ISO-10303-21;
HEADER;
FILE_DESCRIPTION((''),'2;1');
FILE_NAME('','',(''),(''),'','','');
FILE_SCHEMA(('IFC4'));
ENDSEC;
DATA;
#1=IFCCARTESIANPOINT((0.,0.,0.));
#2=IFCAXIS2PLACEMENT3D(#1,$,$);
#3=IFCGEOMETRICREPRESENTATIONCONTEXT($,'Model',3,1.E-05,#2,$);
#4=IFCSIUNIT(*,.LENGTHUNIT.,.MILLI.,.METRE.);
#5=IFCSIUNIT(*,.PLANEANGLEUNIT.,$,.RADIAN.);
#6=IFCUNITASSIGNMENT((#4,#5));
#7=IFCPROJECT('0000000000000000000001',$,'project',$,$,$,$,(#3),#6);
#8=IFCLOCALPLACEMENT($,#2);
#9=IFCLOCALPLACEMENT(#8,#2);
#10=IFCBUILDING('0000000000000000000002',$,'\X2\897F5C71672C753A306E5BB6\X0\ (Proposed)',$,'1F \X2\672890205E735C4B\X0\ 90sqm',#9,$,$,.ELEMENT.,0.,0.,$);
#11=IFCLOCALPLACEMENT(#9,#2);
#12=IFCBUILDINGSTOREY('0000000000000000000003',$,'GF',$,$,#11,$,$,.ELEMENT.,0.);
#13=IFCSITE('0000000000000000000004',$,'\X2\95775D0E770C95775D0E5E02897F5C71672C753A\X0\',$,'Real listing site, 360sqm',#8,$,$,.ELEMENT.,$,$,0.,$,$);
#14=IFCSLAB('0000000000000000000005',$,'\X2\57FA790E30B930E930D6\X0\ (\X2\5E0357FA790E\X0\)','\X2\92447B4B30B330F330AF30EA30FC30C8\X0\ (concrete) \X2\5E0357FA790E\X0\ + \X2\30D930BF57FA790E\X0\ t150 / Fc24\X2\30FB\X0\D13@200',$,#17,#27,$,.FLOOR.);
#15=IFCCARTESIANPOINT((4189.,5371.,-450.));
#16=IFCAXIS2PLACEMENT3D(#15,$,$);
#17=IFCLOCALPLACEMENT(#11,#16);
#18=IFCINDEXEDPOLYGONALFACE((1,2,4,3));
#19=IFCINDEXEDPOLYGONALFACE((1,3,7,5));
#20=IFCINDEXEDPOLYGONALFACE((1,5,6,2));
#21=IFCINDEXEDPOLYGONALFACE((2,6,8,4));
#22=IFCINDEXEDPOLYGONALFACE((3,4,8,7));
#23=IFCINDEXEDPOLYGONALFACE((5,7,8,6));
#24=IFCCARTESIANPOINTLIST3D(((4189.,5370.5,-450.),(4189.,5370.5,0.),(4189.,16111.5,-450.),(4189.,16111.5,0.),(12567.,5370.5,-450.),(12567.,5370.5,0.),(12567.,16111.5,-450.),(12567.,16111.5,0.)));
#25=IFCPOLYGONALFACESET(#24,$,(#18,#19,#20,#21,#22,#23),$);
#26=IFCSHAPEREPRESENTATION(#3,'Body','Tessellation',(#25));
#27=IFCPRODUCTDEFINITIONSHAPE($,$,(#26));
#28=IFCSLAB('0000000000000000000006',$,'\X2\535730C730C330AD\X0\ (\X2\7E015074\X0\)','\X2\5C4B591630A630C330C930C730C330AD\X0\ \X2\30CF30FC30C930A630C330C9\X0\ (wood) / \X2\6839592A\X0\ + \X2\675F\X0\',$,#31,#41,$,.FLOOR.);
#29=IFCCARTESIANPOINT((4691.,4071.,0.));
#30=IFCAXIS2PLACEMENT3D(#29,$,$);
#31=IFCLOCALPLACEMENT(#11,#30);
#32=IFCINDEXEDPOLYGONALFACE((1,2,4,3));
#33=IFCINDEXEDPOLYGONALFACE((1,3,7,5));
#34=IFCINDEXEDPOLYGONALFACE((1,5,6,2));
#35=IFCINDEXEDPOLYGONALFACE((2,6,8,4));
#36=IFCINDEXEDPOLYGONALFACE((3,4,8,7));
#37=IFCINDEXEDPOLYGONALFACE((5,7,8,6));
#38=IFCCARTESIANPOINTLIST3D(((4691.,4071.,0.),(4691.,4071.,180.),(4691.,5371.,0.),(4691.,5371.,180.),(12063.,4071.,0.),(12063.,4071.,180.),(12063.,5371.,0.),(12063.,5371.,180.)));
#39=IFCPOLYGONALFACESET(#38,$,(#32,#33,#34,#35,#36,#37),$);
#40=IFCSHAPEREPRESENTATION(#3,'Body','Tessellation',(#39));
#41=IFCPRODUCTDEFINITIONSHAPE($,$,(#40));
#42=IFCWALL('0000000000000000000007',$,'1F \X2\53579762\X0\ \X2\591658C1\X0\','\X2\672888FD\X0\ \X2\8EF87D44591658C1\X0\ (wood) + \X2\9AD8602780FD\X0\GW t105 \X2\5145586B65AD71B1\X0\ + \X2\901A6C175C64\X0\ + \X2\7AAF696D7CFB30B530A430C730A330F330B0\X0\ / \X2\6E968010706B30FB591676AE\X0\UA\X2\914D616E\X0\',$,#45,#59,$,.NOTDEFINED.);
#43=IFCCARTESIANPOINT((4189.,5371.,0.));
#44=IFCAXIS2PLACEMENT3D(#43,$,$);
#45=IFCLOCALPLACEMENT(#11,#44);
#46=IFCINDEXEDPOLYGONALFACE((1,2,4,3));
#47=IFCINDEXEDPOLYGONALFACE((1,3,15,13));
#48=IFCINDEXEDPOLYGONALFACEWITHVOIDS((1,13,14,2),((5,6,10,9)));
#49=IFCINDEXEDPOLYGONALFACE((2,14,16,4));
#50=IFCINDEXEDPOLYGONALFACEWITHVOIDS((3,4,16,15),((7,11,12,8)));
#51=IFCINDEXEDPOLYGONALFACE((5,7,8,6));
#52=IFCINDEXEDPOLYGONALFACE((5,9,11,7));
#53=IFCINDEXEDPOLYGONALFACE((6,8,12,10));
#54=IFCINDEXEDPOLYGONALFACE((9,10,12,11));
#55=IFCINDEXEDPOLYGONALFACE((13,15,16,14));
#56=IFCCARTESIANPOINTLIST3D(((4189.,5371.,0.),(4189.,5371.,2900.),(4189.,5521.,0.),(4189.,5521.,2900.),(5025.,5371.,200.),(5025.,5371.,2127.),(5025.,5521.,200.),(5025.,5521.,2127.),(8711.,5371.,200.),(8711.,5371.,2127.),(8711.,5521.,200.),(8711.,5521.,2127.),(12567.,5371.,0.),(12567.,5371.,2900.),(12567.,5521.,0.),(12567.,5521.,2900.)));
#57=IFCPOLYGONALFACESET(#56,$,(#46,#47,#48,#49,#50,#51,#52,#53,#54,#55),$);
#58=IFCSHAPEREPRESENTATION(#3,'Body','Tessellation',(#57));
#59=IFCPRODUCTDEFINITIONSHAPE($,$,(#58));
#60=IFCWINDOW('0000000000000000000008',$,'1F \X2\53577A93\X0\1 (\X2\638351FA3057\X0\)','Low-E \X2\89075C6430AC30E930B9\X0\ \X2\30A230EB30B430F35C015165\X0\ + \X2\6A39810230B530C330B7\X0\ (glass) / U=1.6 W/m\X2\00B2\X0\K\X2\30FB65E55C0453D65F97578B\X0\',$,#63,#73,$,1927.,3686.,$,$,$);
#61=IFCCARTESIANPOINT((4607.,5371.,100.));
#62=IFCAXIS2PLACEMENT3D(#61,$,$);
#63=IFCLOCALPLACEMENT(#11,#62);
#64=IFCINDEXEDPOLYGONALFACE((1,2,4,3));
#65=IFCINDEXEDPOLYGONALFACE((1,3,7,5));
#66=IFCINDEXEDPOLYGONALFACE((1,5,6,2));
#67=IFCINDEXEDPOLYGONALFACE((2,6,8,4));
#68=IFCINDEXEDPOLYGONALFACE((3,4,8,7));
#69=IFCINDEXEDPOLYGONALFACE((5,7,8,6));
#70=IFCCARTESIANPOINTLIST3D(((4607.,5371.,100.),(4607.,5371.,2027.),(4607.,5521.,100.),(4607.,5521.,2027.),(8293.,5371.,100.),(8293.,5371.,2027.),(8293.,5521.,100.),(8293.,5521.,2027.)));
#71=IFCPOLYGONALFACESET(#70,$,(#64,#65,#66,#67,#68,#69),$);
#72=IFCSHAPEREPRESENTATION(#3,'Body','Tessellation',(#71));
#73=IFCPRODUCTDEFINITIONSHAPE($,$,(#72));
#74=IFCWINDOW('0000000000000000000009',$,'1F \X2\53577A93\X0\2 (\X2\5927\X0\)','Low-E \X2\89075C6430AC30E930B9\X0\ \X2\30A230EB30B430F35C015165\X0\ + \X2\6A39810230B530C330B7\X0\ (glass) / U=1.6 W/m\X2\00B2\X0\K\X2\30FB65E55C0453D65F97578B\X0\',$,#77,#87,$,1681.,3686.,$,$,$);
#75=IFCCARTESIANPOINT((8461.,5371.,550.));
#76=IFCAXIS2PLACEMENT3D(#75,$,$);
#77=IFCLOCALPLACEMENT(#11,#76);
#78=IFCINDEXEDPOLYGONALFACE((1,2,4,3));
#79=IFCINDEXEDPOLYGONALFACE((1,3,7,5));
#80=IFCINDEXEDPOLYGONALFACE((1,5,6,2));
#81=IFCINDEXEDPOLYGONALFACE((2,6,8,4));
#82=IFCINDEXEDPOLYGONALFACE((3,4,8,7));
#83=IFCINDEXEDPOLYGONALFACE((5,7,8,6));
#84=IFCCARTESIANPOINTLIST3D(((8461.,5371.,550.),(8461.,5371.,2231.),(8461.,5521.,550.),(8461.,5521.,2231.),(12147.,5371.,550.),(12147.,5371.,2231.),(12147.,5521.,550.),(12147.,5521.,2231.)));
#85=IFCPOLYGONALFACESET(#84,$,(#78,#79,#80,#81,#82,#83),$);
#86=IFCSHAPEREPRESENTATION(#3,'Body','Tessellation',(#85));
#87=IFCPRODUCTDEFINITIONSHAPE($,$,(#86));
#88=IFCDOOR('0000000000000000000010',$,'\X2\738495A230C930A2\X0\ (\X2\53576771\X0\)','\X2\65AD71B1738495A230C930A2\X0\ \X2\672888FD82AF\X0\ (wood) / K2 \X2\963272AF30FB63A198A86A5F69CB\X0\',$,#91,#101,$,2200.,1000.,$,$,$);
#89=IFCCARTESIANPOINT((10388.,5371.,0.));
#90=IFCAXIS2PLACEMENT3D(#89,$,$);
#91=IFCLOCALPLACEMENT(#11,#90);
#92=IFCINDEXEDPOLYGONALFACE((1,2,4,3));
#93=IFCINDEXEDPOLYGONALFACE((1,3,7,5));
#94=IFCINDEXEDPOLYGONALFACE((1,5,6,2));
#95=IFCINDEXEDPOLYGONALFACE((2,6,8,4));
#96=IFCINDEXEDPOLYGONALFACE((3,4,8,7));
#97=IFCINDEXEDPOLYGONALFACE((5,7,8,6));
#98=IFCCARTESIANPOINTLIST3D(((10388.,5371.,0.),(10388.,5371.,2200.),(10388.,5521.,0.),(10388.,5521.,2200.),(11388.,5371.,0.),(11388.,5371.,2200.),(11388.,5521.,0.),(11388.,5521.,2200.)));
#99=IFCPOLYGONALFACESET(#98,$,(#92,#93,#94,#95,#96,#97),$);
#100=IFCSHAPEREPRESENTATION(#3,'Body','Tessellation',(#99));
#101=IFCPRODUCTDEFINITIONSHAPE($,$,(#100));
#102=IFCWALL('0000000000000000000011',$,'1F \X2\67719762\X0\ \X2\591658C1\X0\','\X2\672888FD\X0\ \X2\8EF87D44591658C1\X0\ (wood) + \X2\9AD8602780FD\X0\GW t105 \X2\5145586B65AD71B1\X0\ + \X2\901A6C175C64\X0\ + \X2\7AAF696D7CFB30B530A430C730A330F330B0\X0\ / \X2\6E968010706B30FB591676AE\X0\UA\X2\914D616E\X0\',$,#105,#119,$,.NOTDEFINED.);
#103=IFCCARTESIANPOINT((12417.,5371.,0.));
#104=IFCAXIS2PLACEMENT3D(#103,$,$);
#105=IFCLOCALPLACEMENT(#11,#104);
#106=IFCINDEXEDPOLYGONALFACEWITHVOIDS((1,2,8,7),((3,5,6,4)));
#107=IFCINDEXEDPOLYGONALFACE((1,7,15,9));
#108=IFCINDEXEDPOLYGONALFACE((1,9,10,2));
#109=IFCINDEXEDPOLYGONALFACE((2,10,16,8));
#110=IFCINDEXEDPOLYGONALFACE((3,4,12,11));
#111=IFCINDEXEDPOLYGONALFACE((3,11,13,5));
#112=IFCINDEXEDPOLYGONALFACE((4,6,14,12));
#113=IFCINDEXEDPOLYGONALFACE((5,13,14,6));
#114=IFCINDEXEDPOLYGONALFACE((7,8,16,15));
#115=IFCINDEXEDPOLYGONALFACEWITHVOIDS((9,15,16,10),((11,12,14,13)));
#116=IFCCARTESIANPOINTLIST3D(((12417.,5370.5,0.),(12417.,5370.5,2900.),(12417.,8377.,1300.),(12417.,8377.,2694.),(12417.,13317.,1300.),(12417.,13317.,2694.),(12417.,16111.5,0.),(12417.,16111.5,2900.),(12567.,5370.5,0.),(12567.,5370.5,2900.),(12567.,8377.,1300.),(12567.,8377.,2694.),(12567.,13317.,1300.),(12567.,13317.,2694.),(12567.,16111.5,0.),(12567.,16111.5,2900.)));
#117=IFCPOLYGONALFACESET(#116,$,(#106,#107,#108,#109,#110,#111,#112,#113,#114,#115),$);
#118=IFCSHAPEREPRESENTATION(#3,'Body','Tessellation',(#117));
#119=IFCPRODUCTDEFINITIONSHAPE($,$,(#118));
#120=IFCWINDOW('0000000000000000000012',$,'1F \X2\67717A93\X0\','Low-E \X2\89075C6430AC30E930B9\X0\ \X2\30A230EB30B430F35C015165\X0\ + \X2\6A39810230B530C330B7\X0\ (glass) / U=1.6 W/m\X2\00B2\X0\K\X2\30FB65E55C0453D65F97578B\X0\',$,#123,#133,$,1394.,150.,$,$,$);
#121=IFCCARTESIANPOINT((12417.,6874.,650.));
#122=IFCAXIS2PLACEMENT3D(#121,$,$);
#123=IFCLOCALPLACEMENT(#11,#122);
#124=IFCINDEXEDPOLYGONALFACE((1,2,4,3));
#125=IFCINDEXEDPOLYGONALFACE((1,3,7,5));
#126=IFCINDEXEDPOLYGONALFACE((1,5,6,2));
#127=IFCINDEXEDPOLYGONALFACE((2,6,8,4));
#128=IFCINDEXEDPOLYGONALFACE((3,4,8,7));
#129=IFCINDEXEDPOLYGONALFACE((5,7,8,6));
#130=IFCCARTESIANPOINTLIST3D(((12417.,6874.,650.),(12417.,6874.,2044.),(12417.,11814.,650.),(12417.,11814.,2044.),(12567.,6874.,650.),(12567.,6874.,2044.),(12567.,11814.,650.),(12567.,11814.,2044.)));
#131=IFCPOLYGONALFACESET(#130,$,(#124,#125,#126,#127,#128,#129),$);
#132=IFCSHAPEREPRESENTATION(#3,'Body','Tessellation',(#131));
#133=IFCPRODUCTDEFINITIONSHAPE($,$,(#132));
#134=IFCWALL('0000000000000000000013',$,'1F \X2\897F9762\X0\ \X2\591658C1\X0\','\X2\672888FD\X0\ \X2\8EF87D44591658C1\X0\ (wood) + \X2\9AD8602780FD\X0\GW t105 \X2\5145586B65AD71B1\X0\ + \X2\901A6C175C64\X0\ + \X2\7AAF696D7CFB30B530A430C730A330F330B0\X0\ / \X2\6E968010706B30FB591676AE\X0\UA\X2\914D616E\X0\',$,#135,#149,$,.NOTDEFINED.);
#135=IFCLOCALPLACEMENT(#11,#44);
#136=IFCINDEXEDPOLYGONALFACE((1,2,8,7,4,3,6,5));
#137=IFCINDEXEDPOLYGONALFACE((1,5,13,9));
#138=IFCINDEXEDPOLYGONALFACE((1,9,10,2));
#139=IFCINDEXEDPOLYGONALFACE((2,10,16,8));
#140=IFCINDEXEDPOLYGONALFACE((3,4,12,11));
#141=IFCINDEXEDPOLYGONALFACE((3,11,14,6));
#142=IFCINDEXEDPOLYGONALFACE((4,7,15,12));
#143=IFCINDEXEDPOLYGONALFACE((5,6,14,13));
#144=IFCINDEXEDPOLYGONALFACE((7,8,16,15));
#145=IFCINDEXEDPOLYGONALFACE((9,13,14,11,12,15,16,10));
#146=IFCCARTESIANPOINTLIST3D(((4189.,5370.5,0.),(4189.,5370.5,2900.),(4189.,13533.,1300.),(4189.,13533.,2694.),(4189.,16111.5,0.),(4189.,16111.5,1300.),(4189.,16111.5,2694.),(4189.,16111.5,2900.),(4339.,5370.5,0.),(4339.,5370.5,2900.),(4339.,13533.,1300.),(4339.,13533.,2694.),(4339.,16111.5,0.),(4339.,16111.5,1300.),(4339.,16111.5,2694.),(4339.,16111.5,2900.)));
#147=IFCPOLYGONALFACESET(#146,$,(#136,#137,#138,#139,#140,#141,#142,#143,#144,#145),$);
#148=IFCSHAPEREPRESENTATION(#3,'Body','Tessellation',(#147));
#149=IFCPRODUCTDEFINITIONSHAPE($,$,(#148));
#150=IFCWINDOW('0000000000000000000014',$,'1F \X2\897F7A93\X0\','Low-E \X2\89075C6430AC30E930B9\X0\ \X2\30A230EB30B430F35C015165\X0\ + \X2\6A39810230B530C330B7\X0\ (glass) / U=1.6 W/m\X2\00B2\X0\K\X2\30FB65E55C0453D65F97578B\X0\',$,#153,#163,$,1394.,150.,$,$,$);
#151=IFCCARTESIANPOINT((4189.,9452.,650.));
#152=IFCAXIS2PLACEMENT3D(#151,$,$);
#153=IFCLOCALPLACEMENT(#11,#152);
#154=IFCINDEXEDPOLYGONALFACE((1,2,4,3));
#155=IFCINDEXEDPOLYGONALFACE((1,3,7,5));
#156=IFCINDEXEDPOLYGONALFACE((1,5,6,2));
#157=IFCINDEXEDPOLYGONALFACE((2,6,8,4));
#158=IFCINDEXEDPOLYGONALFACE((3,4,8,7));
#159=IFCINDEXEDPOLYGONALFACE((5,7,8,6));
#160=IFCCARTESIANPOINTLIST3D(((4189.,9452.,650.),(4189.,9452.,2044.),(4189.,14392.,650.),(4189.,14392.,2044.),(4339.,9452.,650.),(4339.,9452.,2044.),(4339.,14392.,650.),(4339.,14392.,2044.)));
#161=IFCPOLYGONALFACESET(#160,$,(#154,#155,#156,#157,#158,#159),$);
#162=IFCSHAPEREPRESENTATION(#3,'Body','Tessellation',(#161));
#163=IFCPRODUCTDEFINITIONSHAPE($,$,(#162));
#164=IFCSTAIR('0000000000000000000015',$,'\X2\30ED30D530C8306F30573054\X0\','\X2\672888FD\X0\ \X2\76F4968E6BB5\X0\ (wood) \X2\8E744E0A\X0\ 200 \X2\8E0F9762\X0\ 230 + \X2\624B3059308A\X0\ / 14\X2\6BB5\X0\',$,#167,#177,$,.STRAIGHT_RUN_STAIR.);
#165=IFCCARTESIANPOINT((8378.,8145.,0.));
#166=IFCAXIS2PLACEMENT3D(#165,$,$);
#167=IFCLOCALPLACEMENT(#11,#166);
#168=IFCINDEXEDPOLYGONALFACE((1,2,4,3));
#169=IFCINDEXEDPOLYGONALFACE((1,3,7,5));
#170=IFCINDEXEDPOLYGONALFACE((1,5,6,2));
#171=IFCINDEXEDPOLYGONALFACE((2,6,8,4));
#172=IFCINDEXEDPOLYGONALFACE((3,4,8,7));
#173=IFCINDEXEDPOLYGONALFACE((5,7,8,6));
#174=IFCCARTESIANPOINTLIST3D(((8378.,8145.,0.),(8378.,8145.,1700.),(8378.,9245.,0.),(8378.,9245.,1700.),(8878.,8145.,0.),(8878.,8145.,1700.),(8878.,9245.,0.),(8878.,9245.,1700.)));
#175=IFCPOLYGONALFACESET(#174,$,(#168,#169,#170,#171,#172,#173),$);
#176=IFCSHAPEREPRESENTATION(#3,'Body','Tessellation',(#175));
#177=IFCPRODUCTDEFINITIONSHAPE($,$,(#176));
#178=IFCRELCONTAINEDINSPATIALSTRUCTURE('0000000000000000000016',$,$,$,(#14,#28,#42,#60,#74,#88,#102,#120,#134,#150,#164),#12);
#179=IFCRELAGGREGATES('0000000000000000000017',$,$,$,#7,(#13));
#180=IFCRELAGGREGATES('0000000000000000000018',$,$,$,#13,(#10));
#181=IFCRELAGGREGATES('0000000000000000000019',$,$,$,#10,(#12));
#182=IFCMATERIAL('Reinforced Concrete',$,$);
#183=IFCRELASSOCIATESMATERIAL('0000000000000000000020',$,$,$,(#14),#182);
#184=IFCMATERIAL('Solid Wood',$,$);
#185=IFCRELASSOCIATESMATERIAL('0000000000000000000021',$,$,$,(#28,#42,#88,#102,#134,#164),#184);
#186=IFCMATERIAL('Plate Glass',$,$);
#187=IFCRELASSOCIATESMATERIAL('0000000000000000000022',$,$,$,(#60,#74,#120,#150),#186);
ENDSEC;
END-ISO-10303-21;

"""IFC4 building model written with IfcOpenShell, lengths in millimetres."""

from ifc_helpers import new_model, si_unit, frame, frame_2d, origin, place, context, project, spatial, rectangle, extrude, material, element, fill, save


model = new_model("IFC4")

# Units and contexts
model_context = context("Model", 3, precision=1e-05, world=origin())
ifc_project = project(units=[si_unit("LENGTHUNIT", "METRE", prefix="MILLI"), si_unit("PLANEANGLEUNIT", "RADIAN")], contexts=[model_context])

# Site, building, storey
site_placement = place(None, origin())
site = spatial("IfcSite", under=ifc_project, at=site_placement, Name="長崎県長崎市西山本町", ObjectType="Real listing site, 360sqm", CompositionType="ELEMENT", RefElevation=0.0)
building_placement = place(site_placement, origin())
building = spatial("IfcBuilding", under=site, at=building_placement, Name="西山本町の家 (Proposed)", ObjectType="1F 木造平屋 90sqm", CompositionType="ELEMENT", ElevationOfRefHeight=0.0, ElevationOfTerrain=0.0)
storey_placement = place(building_placement, origin())
storey = spatial("IfcBuildingStorey", under=building, at=storey_placement, Name="GF", CompositionType="ELEMENT", Elevation=0.0)

# Slabs
ifc_material_1 = material(Name="Reinforced Concrete")
slab_1_placement = place(storey_placement, frame((4189.0, 5371.0, -450.0)))
element("IfcSlab", 1, at=slab_1_placement, inside=storey, material=ifc_material_1, Name="基礎スラブ (布基礎)", Description="鉄筋コンクリート (concrete) 布基礎 + ベタ基礎 t150 / Fc24・D13@200", PredefinedType="FLOOR", context=model_context, shape_type="SweptSolid", body=[
    extrude(rectangle(XDim=8378.0, YDim=10741.0, at=frame_2d((4189.0, 5370.0))), frame((4189.0, 5371.0, -450.0)), (0.0, 0.0, 1.0), 450.0),
])
ifc_material_2 = material(Name="Solid Wood")
slab_2_placement = place(storey_placement, frame((4691.0, 4071.0, 0.0)))
element("IfcSlab", 2, at=slab_2_placement, inside=storey, material=ifc_material_2, Name="南デッキ (縁側)", Description="屋外ウッドデッキ ハードウッド (wood) / 根太 + 束", PredefinedType="FLOOR", context=model_context, shape_type="SweptSolid", body=[
    extrude(rectangle(XDim=7372.0, YDim=1300.0, at=frame_2d((3686.0, 650.0))), frame((4691.0, 4071.0, 0.0)), (0.0, 0.0, 1.0), 180.0),
])

# Wall, openings, windows, door
wall_1_placement = place(storey_placement, frame((4189.0, 5371.0, 0.0)))
wall_1 = element("IfcWall", 3, at=wall_1_placement, inside=storey, material=ifc_material_2, Name="1F 南面 外壁", Description="木製 軸組外壁 (wood) + 高性能GW t105 充填断熱 + 通気層 + 窯業系サイディング / 準耐火・外皮UA配慮", PredefinedType="NOTDEFINED", context=model_context, shape_type="SweptSolid", body=[
    extrude(rectangle(XDim=8378.0, YDim=150.0, at=frame_2d((4189.0, 75.0))), frame((4189.0, 5371.0, 0.0)), (0.0, 0.0, 1.0), 2900.0),
])
opening_1_placement = place(storey_placement, frame((4607.0, 5371.0, 100.0)))
opening_1 = element("IfcOpeningElement", 4, at=opening_1_placement, cuts=wall_1, PredefinedType="NOTDEFINED", context=model_context, shape_type="SweptSolid", body=[
    extrude(rectangle(XDim=3686.0, YDim=150.0, at=frame_2d((1843.0, 75.0))), frame((4607.0, 5371.0, 100.0)), (0.0, 0.0, 1.0), 1927.0),
])
opening_2_placement = place(storey_placement, frame((8461.0, 5371.0, 550.0)))
opening_2 = element("IfcOpeningElement", 5, at=opening_2_placement, cuts=wall_1, PredefinedType="NOTDEFINED", context=model_context, shape_type="SweptSolid", body=[
    extrude(rectangle(XDim=3686.0, YDim=150.0, at=frame_2d((1843.0, 75.0))), frame((8461.0, 5371.0, 550.0)), (0.0, 0.0, 1.0), 1681.0),
])
opening_3_placement = place(storey_placement, frame((10388.0, 5371.0, 0.0)))
opening_3 = element("IfcOpeningElement", 6, at=opening_3_placement, cuts=wall_1, PredefinedType="NOTDEFINED", context=model_context, shape_type="SweptSolid", body=[
    extrude(rectangle(XDim=1000.0, YDim=150.0, at=frame_2d((500.0, 75.0))), frame((10388.0, 5371.0, 0.0)), (0.0, 0.0, 1.0), 2200.0),
])
ifc_material_3 = material(Name="Plate Glass")
window_1_placement = place(storey_placement, frame((4607.0, 5371.0, 100.0)))
window_1 = element("IfcWindow", 7, at=window_1_placement, inside=storey, material=ifc_material_3, Name="1F 南窓1 (掃出し)", Description="Low-E 複層ガラス アルゴン封入 + 樹脂サッシ (glass) / U=1.6 W/m²K・日射取得型", OverallHeight=1927.0, OverallWidth=3686.0, context=model_context, shape_type="SweptSolid", body=[
    extrude(rectangle(XDim=3686.0, YDim=150.0, at=frame_2d((1843.0, 75.0))), frame((4607.0, 5371.0, 100.0)), (0.0, 0.0, 1.0), 1927.0),
])
fill(opening_1, window_1)
window_2_placement = place(storey_placement, frame((8461.0, 5371.0, 550.0)))
window_2 = element("IfcWindow", 8, at=window_2_placement, inside=storey, material=ifc_material_3, Name="1F 南窓2 (大)", Description="Low-E 複層ガラス アルゴン封入 + 樹脂サッシ (glass) / U=1.6 W/m²K・日射取得型", OverallHeight=1681.0, OverallWidth=3686.0, context=model_context, shape_type="SweptSolid", body=[
    extrude(rectangle(XDim=3686.0, YDim=150.0, at=frame_2d((1843.0, 75.0))), frame((8461.0, 5371.0, 550.0)), (0.0, 0.0, 1.0), 1681.0),
])
fill(opening_2, window_2)
door_placement = place(storey_placement, frame((10388.0, 5371.0, 0.0)))
door = element("IfcDoor", 9, at=door_placement, inside=storey, material=ifc_material_2, Name="玄関ドア (南東)", Description="断熱玄関ドア 木製芯 (wood) / K2 防犯・採風機構", OverallHeight=2200.0, OverallWidth=1000.0, context=model_context, shape_type="SweptSolid", body=[
    extrude(rectangle(XDim=1000.0, YDim=150.0, at=frame_2d((500.0, 75.0))), frame((10388.0, 5371.0, 0.0)), (0.0, 0.0, 1.0), 2200.0),
])
fill(opening_3, door)

# Walls, openings, windows
wall_2_placement = place(storey_placement, frame((12417.0, 5371.0, 0.0)))
wall_2 = element("IfcWall", 10, at=wall_2_placement, inside=storey, material=ifc_material_2, Name="1F 東面 外壁", Description="木製 軸組外壁 (wood) + 高性能GW t105 充填断熱 + 通気層 + 窯業系サイディング / 準耐火・外皮UA配慮", PredefinedType="NOTDEFINED", context=model_context, shape_type="SweptSolid", body=[
    extrude(rectangle(XDim=150.0, YDim=10741.0, at=frame_2d((75.0, 5370.0))), frame((12417.0, 5371.0, 0.0)), (0.0, 0.0, 1.0), 2900.0),
])
opening_4_placement = place(storey_placement, frame((12417.0, 6874.0, 650.0)))
opening_4 = element("IfcOpeningElement", 11, at=opening_4_placement, cuts=wall_2, PredefinedType="NOTDEFINED", context=model_context, shape_type="SweptSolid", body=[
    extrude(rectangle(XDim=150.0, YDim=4940.0, at=frame_2d((75.0, 2470.0))), frame((12417.0, 6874.0, 650.0)), (0.0, 0.0, 1.0), 1394.0),
])
window_3_placement = place(storey_placement, frame((12417.0, 6874.0, 650.0)))
window_3 = element("IfcWindow", 12, at=window_3_placement, inside=storey, material=ifc_material_3, Name="1F 東窓", Description="Low-E 複層ガラス アルゴン封入 + 樹脂サッシ (glass) / U=1.6 W/m²K・日射取得型", OverallHeight=1394.0, OverallWidth=150.0, context=model_context, shape_type="SweptSolid", body=[
    extrude(rectangle(XDim=150.0, YDim=4940.0, at=frame_2d((75.0, 2470.0))), frame((12417.0, 6874.0, 650.0)), (0.0, 0.0, 1.0), 1394.0),
])
fill(opening_4, window_3)
wall_3_placement = place(storey_placement, frame((4189.0, 5371.0, 0.0)))
wall_3 = element("IfcWall", 13, at=wall_3_placement, inside=storey, material=ifc_material_2, Name="1F 西面 外壁", Description="木製 軸組外壁 (wood) + 高性能GW t105 充填断熱 + 通気層 + 窯業系サイディング / 準耐火・外皮UA配慮", PredefinedType="NOTDEFINED", context=model_context, shape_type="SweptSolid", body=[
    extrude(rectangle(XDim=150.0, YDim=10741.0, at=frame_2d((75.0, 5370.0))), frame((4189.0, 5371.0, 0.0)), (0.0, 0.0, 1.0), 2900.0),
])
opening_5_placement = place(storey_placement, frame((4189.0, 9452.0, 650.0)))
opening_5 = element("IfcOpeningElement", 14, at=opening_5_placement, cuts=wall_3, PredefinedType="NOTDEFINED", context=model_context, shape_type="SweptSolid", body=[
    extrude(rectangle(XDim=150.0, YDim=4940.0, at=frame_2d((75.0, 2470.0))), frame((4189.0, 9452.0, 650.0)), (0.0, 0.0, 1.0), 1394.0),
])
window_4_placement = place(storey_placement, frame((4189.0, 9452.0, 650.0)))
window_4 = element("IfcWindow", 15, at=window_4_placement, inside=storey, material=ifc_material_3, Name="1F 西窓", Description="Low-E 複層ガラス アルゴン封入 + 樹脂サッシ (glass) / U=1.6 W/m²K・日射取得型", OverallHeight=1394.0, OverallWidth=150.0, context=model_context, shape_type="SweptSolid", body=[
    extrude(rectangle(XDim=150.0, YDim=4940.0, at=frame_2d((75.0, 2470.0))), frame((4189.0, 9452.0, 650.0)), (0.0, 0.0, 1.0), 1394.0),
])
fill(opening_5, window_4)

# Stair
stair_placement = place(storey_placement, frame((8378.0, 8145.0, 0.0)))
element("IfcStair", 16, at=stair_placement, inside=storey, material=ifc_material_2, Name="ロフトはしご", Description="木製 直階段 (wood) 蹴上 200 踏面 230 + 手すり / 14段", PredefinedType="STRAIGHT_RUN_STAIR", context=model_context, shape_type="SweptSolid", body=[
    extrude(rectangle(XDim=500.0, YDim=1100.0, at=frame_2d((250.0, 550.0))), frame((8378.0, 8145.0, 0.0)), (0.0, 0.0, 1.0), 1700.0),
])

save(model, "model.ifc")
